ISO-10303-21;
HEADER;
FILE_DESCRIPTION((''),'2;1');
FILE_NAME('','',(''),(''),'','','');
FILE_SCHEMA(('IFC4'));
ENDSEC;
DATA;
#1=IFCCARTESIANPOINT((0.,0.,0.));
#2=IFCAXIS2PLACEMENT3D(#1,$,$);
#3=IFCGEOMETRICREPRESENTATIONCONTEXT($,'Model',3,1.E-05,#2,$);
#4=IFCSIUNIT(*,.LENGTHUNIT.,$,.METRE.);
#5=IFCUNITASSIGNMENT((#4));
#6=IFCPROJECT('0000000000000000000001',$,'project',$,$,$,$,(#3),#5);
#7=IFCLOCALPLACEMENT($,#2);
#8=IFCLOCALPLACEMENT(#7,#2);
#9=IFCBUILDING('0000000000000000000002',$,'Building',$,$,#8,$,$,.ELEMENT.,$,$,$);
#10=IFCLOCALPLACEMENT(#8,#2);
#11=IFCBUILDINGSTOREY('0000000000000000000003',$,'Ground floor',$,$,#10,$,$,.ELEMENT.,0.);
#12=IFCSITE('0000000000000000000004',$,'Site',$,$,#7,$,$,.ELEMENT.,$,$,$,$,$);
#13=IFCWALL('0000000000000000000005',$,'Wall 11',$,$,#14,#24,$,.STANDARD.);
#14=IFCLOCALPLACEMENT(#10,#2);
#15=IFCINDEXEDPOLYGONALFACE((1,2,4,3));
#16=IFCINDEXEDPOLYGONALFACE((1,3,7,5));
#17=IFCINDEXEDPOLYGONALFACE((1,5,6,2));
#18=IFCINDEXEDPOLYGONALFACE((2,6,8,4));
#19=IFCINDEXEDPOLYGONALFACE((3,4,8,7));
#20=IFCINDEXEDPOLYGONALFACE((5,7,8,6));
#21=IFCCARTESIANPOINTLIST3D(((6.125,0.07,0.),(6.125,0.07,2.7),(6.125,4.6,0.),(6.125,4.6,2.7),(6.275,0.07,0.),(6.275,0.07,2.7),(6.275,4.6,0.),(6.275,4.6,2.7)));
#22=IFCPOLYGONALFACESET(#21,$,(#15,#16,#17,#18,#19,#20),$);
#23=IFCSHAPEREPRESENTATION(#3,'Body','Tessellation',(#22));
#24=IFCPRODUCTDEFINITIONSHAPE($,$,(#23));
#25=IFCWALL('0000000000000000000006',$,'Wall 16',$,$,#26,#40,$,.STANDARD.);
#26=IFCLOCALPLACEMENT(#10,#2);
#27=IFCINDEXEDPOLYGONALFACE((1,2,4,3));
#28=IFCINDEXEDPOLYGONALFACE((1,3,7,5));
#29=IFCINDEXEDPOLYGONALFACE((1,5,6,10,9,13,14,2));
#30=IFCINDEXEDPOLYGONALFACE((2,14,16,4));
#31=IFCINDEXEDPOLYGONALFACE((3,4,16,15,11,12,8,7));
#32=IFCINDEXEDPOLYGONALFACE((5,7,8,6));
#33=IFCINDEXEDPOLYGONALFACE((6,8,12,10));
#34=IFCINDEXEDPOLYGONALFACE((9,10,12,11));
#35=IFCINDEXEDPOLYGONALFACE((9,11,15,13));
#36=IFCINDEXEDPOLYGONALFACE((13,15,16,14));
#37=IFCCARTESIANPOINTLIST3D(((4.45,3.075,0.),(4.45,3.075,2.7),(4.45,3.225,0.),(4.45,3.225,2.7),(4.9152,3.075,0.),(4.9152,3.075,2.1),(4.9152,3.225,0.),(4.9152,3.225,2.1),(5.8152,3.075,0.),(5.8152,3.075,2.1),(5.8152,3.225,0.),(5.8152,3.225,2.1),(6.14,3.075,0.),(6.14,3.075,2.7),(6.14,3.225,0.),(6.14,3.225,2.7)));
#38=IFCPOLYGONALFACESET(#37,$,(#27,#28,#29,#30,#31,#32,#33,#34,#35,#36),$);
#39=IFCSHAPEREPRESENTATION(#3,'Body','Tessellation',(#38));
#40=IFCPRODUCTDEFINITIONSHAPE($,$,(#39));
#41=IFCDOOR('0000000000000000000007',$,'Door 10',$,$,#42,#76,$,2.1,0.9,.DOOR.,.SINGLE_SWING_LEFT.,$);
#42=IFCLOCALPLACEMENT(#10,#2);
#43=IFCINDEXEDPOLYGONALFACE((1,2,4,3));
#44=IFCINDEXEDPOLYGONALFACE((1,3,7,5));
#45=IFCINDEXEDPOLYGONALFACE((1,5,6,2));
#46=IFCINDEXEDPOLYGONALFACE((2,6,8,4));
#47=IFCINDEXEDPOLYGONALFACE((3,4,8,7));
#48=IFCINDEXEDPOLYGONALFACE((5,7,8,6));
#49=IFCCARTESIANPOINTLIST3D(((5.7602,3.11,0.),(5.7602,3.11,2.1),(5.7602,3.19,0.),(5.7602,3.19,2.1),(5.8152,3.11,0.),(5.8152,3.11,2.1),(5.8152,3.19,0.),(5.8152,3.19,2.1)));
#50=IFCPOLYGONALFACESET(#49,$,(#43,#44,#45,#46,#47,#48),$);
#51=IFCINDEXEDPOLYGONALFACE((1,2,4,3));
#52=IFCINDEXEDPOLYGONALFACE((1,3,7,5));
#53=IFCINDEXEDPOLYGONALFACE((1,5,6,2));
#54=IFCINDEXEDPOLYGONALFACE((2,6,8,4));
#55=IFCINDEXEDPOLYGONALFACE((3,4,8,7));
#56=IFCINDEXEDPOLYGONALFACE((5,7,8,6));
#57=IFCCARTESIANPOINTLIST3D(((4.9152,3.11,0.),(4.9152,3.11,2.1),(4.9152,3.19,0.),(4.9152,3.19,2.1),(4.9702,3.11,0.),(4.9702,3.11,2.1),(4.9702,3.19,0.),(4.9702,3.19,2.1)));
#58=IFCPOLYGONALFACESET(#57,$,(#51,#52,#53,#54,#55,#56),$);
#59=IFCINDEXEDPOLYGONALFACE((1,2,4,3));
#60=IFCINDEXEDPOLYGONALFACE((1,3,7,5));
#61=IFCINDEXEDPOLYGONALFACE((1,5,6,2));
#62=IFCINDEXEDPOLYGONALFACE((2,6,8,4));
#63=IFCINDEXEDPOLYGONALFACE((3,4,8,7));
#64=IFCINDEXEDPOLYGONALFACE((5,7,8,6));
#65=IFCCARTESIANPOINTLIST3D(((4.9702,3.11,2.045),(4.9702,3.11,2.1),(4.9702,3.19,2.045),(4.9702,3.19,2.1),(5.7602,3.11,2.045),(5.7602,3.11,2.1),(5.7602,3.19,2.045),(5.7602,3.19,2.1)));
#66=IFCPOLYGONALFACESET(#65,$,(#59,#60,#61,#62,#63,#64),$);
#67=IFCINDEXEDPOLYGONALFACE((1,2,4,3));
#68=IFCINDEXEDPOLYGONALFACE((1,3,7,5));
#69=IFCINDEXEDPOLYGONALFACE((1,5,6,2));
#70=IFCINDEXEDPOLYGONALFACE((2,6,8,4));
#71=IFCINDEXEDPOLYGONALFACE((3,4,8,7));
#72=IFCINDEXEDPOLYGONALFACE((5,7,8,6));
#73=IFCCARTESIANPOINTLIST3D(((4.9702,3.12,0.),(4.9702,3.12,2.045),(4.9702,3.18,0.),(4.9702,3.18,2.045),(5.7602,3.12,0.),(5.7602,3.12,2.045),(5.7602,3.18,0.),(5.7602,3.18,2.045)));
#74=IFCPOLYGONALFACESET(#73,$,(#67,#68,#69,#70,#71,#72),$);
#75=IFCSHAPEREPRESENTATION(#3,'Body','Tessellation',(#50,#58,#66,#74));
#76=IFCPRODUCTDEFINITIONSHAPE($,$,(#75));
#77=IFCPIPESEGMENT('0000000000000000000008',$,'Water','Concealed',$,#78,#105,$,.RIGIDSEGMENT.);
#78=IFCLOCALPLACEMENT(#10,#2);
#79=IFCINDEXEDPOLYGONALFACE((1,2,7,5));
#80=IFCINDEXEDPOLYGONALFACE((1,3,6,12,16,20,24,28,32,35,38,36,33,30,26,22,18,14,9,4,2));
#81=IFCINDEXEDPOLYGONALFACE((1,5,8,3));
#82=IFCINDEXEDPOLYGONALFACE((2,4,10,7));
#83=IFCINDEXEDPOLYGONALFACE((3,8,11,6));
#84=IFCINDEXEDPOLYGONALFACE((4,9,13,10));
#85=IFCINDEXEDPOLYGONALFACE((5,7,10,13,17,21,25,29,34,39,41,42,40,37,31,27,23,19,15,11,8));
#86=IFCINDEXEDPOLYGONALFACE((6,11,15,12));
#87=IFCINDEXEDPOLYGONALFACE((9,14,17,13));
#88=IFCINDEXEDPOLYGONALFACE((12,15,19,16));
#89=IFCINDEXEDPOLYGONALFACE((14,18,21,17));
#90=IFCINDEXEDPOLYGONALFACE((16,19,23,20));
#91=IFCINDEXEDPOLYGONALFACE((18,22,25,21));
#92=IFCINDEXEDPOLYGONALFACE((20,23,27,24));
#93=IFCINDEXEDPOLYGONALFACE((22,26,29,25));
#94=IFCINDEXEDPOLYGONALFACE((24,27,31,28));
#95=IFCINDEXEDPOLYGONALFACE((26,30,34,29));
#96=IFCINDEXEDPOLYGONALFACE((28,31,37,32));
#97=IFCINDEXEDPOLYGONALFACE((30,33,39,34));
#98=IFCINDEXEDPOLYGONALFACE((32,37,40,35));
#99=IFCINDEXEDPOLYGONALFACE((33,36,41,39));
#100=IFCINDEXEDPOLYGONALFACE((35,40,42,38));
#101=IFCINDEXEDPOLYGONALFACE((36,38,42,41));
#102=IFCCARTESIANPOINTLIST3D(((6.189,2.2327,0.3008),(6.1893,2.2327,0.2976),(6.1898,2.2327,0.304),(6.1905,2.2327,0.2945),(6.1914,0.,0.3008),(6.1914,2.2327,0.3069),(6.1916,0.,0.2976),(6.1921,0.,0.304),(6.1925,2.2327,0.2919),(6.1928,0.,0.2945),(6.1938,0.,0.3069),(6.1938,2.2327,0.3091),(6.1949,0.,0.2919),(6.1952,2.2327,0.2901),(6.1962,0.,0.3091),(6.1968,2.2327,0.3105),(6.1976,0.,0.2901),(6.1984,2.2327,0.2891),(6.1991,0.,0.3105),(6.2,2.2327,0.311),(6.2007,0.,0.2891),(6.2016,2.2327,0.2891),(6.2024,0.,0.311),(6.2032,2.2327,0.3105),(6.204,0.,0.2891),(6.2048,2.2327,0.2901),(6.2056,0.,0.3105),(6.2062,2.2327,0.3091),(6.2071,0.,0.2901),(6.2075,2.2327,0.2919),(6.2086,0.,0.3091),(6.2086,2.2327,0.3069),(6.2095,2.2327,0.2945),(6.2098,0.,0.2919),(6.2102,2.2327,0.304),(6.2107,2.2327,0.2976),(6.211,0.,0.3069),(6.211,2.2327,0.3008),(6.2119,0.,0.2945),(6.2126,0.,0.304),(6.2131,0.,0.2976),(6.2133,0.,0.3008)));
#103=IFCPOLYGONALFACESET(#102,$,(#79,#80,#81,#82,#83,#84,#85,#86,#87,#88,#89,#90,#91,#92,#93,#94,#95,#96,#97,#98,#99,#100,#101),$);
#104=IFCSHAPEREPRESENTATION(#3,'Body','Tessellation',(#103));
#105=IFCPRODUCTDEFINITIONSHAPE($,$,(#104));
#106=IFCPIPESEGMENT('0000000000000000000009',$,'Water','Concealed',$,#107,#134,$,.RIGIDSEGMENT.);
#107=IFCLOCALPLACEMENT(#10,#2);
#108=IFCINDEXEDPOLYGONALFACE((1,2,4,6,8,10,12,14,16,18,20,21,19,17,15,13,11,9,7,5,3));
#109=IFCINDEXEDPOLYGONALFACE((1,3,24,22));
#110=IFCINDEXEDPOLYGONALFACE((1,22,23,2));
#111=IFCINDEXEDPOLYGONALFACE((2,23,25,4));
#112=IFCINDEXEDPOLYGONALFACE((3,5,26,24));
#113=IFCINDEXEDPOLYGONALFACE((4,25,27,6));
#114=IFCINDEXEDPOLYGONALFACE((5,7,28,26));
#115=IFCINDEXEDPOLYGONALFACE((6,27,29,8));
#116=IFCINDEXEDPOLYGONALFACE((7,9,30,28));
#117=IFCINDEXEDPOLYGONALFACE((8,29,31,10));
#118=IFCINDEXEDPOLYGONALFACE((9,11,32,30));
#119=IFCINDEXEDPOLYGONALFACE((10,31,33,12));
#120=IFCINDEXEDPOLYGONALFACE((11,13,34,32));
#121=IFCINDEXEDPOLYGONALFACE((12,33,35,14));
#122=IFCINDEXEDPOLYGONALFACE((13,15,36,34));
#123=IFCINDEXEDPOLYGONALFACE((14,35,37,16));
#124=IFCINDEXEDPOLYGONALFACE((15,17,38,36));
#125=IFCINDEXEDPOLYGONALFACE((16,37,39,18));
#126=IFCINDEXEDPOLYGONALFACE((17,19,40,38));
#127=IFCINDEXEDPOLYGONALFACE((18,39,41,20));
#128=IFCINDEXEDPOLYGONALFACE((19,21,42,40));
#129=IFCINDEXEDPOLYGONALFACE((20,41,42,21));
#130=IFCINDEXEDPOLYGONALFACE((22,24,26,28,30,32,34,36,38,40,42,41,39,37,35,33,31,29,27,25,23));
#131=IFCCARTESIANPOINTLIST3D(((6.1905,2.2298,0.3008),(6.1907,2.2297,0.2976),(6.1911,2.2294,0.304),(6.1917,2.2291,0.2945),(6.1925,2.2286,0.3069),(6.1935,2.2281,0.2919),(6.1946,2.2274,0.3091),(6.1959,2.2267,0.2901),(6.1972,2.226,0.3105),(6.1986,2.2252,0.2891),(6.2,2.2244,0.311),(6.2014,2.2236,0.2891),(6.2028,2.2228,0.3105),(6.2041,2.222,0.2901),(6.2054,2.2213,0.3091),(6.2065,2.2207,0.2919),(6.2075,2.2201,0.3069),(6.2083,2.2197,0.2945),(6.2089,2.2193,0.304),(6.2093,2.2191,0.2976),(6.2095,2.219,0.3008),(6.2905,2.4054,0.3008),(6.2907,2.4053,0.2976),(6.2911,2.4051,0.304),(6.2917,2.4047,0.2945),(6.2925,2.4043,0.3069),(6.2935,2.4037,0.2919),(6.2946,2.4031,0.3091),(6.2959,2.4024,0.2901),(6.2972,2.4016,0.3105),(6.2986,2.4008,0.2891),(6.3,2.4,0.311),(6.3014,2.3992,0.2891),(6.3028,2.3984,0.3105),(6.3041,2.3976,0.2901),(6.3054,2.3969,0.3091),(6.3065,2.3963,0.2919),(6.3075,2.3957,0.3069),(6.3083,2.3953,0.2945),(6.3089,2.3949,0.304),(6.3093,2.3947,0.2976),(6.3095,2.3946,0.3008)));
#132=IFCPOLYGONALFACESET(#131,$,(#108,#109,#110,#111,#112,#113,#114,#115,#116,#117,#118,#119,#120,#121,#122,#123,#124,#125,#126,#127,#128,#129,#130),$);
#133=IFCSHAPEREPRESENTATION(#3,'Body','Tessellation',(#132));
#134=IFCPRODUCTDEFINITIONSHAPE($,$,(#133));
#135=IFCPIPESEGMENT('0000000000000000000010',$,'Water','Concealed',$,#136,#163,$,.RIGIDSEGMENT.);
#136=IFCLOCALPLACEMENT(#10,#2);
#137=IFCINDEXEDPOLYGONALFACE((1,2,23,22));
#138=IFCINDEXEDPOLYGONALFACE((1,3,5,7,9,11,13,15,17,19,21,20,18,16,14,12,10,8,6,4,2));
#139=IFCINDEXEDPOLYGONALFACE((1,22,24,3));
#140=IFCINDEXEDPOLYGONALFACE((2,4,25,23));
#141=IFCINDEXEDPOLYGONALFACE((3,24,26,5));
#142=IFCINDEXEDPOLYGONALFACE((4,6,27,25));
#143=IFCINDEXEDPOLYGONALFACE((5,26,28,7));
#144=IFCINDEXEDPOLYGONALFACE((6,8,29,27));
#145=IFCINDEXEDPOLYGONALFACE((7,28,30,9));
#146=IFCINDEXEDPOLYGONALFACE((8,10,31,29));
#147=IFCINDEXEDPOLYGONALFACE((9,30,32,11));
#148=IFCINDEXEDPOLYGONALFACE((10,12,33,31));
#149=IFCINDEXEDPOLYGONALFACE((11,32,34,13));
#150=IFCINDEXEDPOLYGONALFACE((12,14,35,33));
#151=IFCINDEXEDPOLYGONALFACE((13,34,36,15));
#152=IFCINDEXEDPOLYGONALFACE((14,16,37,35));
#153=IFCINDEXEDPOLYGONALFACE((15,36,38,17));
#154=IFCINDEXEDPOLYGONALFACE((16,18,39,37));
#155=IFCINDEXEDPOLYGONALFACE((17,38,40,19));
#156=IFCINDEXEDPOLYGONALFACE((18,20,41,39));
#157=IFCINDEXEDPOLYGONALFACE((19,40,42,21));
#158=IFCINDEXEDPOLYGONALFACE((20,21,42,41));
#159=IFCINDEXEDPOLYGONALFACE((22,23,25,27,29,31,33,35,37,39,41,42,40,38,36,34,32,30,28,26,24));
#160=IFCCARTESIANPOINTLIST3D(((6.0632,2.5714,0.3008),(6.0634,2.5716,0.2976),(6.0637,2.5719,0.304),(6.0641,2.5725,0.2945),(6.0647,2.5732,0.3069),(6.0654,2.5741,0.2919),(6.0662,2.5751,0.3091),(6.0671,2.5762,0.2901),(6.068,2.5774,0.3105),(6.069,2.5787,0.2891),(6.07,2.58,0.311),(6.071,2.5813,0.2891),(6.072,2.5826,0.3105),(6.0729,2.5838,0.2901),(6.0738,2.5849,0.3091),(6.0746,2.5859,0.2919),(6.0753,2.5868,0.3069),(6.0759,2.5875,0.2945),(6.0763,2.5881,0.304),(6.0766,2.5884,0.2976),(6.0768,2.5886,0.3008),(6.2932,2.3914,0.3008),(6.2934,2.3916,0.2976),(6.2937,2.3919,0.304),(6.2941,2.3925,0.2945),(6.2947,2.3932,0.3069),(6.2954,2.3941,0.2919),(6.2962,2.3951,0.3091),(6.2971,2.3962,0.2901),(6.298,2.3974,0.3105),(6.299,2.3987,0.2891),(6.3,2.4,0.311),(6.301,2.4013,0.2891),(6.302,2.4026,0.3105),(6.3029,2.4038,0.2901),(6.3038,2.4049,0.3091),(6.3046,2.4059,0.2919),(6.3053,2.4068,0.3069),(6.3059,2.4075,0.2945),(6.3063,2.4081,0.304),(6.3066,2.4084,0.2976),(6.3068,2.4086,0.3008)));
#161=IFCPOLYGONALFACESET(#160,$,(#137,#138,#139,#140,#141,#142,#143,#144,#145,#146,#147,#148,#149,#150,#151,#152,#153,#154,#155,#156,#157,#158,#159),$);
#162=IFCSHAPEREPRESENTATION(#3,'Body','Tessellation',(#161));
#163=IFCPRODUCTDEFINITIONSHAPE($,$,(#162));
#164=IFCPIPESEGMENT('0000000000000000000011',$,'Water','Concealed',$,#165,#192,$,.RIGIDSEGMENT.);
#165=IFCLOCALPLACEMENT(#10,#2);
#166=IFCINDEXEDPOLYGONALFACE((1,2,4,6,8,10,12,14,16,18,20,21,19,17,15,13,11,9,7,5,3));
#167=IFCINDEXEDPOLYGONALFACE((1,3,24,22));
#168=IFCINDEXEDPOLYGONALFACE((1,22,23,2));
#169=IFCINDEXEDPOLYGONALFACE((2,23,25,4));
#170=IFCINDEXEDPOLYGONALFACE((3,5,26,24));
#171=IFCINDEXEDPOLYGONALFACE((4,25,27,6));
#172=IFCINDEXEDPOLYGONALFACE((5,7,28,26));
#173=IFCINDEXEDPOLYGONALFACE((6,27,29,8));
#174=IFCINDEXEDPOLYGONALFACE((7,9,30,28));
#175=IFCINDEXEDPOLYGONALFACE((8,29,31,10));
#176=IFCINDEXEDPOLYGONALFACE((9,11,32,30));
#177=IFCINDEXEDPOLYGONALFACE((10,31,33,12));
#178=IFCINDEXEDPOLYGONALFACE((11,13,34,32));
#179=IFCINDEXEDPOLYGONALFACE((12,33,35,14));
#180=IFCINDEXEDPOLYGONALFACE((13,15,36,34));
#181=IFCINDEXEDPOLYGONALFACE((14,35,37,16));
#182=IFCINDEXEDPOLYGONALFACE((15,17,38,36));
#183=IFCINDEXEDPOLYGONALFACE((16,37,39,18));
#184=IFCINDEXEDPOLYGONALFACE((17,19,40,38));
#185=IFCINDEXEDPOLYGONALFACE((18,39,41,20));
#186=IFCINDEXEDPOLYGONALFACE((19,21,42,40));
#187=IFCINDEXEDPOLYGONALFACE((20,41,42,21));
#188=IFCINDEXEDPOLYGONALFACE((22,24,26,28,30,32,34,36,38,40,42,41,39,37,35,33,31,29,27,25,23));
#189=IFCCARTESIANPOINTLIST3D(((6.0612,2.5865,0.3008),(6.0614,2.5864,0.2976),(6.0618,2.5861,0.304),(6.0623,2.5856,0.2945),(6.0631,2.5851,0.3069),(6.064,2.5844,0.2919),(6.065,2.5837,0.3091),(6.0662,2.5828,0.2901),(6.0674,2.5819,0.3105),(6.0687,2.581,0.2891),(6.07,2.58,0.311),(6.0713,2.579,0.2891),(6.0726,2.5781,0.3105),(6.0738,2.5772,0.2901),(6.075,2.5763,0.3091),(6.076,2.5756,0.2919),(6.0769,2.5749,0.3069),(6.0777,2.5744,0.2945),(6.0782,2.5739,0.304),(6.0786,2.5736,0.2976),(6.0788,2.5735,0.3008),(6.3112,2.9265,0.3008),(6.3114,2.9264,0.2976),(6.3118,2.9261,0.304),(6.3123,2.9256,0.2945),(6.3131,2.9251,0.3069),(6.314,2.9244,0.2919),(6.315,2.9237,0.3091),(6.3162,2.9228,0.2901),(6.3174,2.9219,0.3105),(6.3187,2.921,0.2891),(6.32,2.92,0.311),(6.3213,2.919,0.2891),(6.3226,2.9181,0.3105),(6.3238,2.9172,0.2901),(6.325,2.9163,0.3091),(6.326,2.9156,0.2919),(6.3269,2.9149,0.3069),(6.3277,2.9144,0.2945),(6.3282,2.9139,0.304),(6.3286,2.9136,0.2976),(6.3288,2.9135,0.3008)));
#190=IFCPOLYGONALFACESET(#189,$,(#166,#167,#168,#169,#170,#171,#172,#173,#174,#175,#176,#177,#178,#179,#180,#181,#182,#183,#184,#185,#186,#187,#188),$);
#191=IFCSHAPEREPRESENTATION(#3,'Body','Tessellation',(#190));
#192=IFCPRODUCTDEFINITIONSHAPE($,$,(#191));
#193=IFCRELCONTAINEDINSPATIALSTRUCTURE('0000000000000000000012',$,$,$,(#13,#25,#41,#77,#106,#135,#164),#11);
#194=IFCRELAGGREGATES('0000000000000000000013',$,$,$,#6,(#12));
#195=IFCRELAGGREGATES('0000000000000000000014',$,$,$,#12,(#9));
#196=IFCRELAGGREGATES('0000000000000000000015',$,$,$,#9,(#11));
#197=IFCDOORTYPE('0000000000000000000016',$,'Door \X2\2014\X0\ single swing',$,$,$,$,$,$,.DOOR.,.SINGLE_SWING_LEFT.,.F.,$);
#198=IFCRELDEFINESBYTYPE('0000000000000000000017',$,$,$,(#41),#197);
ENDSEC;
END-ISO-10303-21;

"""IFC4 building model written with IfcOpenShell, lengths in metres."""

from ifc_helpers import new_model, si_unit, frame, frame_2d, origin, origin_2d, place, context, project, spatial, rectangle, circle, extrude, type_object, element, fill, save


model = new_model("IFC4")

# Units and contexts
model_context = context("Model", 3, precision=1e-05, world=origin())
ifc_project = project(units=[si_unit("LENGTHUNIT", "METRE")], contexts=[model_context])

# Site, building, storey
site_placement = place(None, origin())
site = spatial("IfcSite", under=ifc_project, at=site_placement, Name="Site", CompositionType="ELEMENT")
building_placement = place(site_placement, origin())
building = spatial("IfcBuilding", under=site, at=building_placement, Name="Building", CompositionType="ELEMENT")
storey_placement = place(building_placement, origin())
storey = spatial("IfcBuildingStorey", under=building, at=storey_placement, Name="Ground floor", CompositionType="ELEMENT", Elevation=0.0)

# Wall
wall_1_placement = place(storey_placement, frame((6.2, 4.6, 0.0), z_axis=(0.0, 0.0, 1.0), x_axis=(0.0, -1.0, 0.0)))
element("IfcWall", 1, at=wall_1_placement, inside=storey, Name="Wall 11", PredefinedType="STANDARD", context=model_context, shape_type="SweptSolid", body=[
    extrude(rectangle(XDim=4.53, YDim=0.15, at=frame_2d((2.265, 0.0))), origin(), (0.0, 0.0, 1.0), 2.7),
])

# Wall, opening, door
wall_2_placement = place(storey_placement, frame((6.14, 3.15, 0.0), z_axis=(0.0, 0.0, 1.0), x_axis=(-1.0, 0.0, 0.0)))
wall_2 = element("IfcWall", 2, at=wall_2_placement, inside=storey, Name="Wall 16", PredefinedType="STANDARD", context=model_context, shape_type="SweptSolid", body=[
    extrude(rectangle(XDim=1.69, YDim=0.15, at=frame_2d((0.845, 0.0))), origin(), (0.0, 0.0, 1.0), 2.7),
])
opening_placement = place(storey_placement, frame((5.8152, 3.15, 0.0), z_axis=(0.0, 0.0, 1.0), x_axis=(-1.0, 0.0, 0.0)))
opening = element("IfcOpeningElement", 3, at=opening_placement, cuts=wall_2, PredefinedType="OPENING", context=model_context, shape_type="SweptSolid", body=[
    extrude(rectangle(XDim=0.9, YDim=0.21, at=frame_2d((0.45, 0.0))), origin(), (0.0, 0.0, 1.0), 2.1),
])
door_type = type_object("IfcDoorType", Name="Door — single swing", OperationType="SINGLE_SWING_LEFT", ParameterTakesPrecedence=False, PredefinedType="DOOR")
door_placement = place(storey_placement, frame((5.8152, 3.15, 0.0), z_axis=(0.0, 0.0, 1.0), x_axis=(-1.0, 0.0, 0.0)))
door = element("IfcDoor", 4, at=door_placement, inside=storey, type_object=door_type, Name="Door 10", OperationType="SINGLE_SWING_LEFT", OverallHeight=2.1, OverallWidth=0.9, PredefinedType="DOOR", context=model_context, shape_type="SweptSolid", body=[
    extrude(rectangle(XDim=0.055, YDim=0.08, at=frame_2d((0.0275, 0.0))), origin(), (0.0, 0.0, 1.0), 2.1),
    extrude(rectangle(XDim=0.055, YDim=0.08, at=frame_2d((0.8725, 0.0))), origin(), (0.0, 0.0, 1.0), 2.1),
    extrude(rectangle(XDim=0.79, YDim=0.08, at=frame_2d((0.45, 0.0))), frame((0.0, 0.0, 2.045)), (0.0, 0.0, 1.0), 0.055),
    extrude(rectangle(XDim=0.79, YDim=0.06, at=frame_2d((0.45, 0.0))), origin(), (0.0, 0.0, 1.0), 2.045),
])
fill(opening, door)

# Pipe segments
pipe_segment_1_placement = place(storey_placement, frame((6.2024, 0.0, 0.3), z_axis=(-0.001056, 0.999999, 0.0), x_axis=(0.0, 0.0, 1.0)))
element("IfcPipeSegment", 5, at=pipe_segment_1_placement, inside=storey, Name="Water", Description="Concealed", PredefinedType="RIGIDSEGMENT", context=model_context, shape_type="SweptSolid", body=[
    extrude(circle(Radius=0.011, at=origin_2d()), origin(), (0.0, 0.0, 1.0), 2.2327),
])
pipe_segment_2_placement = place(storey_placement, frame((6.2, 2.2244, 0.3), z_axis=(0.494813, 0.869, 0.0), x_axis=(0.0, 0.0, 1.0)))
element("IfcPipeSegment", 6, at=pipe_segment_2_placement, inside=storey, Name="Water", Description="Concealed", PredefinedType="RIGIDSEGMENT", context=model_context, shape_type="SweptSolid", body=[
    extrude(circle(Radius=0.011, at=origin_2d()), origin(), (0.0, 0.0, 1.0), 0.2021),
])
pipe_segment_3_placement = place(storey_placement, frame((6.3, 2.4, 0.3), z_axis=(-0.787505, 0.616308, 0.0), x_axis=(0.0, 0.0, 1.0)))
element("IfcPipeSegment", 7, at=pipe_segment_3_placement, inside=storey, Name="Water", Description="Concealed", PredefinedType="RIGIDSEGMENT", context=model_context, shape_type="SweptSolid", body=[
    extrude(circle(Radius=0.011, at=origin_2d()), origin(), (0.0, 0.0, 1.0), 0.2921),
])
pipe_segment_4_placement = place(storey_placement, frame((6.07, 2.58, 0.3), z_axis=(0.59239, 0.805651, 0.0), x_axis=(0.0, 0.0, 1.0)))
element("IfcPipeSegment", 8, at=pipe_segment_4_placement, inside=storey, Name="Water", Description="Concealed", PredefinedType="RIGIDSEGMENT", context=model_context, shape_type="SweptSolid", body=[
    extrude(circle(Radius=0.011, at=origin_2d()), origin(), (0.0, 0.0, 1.0), 0.422),
])

save(model, "model.ifc")
